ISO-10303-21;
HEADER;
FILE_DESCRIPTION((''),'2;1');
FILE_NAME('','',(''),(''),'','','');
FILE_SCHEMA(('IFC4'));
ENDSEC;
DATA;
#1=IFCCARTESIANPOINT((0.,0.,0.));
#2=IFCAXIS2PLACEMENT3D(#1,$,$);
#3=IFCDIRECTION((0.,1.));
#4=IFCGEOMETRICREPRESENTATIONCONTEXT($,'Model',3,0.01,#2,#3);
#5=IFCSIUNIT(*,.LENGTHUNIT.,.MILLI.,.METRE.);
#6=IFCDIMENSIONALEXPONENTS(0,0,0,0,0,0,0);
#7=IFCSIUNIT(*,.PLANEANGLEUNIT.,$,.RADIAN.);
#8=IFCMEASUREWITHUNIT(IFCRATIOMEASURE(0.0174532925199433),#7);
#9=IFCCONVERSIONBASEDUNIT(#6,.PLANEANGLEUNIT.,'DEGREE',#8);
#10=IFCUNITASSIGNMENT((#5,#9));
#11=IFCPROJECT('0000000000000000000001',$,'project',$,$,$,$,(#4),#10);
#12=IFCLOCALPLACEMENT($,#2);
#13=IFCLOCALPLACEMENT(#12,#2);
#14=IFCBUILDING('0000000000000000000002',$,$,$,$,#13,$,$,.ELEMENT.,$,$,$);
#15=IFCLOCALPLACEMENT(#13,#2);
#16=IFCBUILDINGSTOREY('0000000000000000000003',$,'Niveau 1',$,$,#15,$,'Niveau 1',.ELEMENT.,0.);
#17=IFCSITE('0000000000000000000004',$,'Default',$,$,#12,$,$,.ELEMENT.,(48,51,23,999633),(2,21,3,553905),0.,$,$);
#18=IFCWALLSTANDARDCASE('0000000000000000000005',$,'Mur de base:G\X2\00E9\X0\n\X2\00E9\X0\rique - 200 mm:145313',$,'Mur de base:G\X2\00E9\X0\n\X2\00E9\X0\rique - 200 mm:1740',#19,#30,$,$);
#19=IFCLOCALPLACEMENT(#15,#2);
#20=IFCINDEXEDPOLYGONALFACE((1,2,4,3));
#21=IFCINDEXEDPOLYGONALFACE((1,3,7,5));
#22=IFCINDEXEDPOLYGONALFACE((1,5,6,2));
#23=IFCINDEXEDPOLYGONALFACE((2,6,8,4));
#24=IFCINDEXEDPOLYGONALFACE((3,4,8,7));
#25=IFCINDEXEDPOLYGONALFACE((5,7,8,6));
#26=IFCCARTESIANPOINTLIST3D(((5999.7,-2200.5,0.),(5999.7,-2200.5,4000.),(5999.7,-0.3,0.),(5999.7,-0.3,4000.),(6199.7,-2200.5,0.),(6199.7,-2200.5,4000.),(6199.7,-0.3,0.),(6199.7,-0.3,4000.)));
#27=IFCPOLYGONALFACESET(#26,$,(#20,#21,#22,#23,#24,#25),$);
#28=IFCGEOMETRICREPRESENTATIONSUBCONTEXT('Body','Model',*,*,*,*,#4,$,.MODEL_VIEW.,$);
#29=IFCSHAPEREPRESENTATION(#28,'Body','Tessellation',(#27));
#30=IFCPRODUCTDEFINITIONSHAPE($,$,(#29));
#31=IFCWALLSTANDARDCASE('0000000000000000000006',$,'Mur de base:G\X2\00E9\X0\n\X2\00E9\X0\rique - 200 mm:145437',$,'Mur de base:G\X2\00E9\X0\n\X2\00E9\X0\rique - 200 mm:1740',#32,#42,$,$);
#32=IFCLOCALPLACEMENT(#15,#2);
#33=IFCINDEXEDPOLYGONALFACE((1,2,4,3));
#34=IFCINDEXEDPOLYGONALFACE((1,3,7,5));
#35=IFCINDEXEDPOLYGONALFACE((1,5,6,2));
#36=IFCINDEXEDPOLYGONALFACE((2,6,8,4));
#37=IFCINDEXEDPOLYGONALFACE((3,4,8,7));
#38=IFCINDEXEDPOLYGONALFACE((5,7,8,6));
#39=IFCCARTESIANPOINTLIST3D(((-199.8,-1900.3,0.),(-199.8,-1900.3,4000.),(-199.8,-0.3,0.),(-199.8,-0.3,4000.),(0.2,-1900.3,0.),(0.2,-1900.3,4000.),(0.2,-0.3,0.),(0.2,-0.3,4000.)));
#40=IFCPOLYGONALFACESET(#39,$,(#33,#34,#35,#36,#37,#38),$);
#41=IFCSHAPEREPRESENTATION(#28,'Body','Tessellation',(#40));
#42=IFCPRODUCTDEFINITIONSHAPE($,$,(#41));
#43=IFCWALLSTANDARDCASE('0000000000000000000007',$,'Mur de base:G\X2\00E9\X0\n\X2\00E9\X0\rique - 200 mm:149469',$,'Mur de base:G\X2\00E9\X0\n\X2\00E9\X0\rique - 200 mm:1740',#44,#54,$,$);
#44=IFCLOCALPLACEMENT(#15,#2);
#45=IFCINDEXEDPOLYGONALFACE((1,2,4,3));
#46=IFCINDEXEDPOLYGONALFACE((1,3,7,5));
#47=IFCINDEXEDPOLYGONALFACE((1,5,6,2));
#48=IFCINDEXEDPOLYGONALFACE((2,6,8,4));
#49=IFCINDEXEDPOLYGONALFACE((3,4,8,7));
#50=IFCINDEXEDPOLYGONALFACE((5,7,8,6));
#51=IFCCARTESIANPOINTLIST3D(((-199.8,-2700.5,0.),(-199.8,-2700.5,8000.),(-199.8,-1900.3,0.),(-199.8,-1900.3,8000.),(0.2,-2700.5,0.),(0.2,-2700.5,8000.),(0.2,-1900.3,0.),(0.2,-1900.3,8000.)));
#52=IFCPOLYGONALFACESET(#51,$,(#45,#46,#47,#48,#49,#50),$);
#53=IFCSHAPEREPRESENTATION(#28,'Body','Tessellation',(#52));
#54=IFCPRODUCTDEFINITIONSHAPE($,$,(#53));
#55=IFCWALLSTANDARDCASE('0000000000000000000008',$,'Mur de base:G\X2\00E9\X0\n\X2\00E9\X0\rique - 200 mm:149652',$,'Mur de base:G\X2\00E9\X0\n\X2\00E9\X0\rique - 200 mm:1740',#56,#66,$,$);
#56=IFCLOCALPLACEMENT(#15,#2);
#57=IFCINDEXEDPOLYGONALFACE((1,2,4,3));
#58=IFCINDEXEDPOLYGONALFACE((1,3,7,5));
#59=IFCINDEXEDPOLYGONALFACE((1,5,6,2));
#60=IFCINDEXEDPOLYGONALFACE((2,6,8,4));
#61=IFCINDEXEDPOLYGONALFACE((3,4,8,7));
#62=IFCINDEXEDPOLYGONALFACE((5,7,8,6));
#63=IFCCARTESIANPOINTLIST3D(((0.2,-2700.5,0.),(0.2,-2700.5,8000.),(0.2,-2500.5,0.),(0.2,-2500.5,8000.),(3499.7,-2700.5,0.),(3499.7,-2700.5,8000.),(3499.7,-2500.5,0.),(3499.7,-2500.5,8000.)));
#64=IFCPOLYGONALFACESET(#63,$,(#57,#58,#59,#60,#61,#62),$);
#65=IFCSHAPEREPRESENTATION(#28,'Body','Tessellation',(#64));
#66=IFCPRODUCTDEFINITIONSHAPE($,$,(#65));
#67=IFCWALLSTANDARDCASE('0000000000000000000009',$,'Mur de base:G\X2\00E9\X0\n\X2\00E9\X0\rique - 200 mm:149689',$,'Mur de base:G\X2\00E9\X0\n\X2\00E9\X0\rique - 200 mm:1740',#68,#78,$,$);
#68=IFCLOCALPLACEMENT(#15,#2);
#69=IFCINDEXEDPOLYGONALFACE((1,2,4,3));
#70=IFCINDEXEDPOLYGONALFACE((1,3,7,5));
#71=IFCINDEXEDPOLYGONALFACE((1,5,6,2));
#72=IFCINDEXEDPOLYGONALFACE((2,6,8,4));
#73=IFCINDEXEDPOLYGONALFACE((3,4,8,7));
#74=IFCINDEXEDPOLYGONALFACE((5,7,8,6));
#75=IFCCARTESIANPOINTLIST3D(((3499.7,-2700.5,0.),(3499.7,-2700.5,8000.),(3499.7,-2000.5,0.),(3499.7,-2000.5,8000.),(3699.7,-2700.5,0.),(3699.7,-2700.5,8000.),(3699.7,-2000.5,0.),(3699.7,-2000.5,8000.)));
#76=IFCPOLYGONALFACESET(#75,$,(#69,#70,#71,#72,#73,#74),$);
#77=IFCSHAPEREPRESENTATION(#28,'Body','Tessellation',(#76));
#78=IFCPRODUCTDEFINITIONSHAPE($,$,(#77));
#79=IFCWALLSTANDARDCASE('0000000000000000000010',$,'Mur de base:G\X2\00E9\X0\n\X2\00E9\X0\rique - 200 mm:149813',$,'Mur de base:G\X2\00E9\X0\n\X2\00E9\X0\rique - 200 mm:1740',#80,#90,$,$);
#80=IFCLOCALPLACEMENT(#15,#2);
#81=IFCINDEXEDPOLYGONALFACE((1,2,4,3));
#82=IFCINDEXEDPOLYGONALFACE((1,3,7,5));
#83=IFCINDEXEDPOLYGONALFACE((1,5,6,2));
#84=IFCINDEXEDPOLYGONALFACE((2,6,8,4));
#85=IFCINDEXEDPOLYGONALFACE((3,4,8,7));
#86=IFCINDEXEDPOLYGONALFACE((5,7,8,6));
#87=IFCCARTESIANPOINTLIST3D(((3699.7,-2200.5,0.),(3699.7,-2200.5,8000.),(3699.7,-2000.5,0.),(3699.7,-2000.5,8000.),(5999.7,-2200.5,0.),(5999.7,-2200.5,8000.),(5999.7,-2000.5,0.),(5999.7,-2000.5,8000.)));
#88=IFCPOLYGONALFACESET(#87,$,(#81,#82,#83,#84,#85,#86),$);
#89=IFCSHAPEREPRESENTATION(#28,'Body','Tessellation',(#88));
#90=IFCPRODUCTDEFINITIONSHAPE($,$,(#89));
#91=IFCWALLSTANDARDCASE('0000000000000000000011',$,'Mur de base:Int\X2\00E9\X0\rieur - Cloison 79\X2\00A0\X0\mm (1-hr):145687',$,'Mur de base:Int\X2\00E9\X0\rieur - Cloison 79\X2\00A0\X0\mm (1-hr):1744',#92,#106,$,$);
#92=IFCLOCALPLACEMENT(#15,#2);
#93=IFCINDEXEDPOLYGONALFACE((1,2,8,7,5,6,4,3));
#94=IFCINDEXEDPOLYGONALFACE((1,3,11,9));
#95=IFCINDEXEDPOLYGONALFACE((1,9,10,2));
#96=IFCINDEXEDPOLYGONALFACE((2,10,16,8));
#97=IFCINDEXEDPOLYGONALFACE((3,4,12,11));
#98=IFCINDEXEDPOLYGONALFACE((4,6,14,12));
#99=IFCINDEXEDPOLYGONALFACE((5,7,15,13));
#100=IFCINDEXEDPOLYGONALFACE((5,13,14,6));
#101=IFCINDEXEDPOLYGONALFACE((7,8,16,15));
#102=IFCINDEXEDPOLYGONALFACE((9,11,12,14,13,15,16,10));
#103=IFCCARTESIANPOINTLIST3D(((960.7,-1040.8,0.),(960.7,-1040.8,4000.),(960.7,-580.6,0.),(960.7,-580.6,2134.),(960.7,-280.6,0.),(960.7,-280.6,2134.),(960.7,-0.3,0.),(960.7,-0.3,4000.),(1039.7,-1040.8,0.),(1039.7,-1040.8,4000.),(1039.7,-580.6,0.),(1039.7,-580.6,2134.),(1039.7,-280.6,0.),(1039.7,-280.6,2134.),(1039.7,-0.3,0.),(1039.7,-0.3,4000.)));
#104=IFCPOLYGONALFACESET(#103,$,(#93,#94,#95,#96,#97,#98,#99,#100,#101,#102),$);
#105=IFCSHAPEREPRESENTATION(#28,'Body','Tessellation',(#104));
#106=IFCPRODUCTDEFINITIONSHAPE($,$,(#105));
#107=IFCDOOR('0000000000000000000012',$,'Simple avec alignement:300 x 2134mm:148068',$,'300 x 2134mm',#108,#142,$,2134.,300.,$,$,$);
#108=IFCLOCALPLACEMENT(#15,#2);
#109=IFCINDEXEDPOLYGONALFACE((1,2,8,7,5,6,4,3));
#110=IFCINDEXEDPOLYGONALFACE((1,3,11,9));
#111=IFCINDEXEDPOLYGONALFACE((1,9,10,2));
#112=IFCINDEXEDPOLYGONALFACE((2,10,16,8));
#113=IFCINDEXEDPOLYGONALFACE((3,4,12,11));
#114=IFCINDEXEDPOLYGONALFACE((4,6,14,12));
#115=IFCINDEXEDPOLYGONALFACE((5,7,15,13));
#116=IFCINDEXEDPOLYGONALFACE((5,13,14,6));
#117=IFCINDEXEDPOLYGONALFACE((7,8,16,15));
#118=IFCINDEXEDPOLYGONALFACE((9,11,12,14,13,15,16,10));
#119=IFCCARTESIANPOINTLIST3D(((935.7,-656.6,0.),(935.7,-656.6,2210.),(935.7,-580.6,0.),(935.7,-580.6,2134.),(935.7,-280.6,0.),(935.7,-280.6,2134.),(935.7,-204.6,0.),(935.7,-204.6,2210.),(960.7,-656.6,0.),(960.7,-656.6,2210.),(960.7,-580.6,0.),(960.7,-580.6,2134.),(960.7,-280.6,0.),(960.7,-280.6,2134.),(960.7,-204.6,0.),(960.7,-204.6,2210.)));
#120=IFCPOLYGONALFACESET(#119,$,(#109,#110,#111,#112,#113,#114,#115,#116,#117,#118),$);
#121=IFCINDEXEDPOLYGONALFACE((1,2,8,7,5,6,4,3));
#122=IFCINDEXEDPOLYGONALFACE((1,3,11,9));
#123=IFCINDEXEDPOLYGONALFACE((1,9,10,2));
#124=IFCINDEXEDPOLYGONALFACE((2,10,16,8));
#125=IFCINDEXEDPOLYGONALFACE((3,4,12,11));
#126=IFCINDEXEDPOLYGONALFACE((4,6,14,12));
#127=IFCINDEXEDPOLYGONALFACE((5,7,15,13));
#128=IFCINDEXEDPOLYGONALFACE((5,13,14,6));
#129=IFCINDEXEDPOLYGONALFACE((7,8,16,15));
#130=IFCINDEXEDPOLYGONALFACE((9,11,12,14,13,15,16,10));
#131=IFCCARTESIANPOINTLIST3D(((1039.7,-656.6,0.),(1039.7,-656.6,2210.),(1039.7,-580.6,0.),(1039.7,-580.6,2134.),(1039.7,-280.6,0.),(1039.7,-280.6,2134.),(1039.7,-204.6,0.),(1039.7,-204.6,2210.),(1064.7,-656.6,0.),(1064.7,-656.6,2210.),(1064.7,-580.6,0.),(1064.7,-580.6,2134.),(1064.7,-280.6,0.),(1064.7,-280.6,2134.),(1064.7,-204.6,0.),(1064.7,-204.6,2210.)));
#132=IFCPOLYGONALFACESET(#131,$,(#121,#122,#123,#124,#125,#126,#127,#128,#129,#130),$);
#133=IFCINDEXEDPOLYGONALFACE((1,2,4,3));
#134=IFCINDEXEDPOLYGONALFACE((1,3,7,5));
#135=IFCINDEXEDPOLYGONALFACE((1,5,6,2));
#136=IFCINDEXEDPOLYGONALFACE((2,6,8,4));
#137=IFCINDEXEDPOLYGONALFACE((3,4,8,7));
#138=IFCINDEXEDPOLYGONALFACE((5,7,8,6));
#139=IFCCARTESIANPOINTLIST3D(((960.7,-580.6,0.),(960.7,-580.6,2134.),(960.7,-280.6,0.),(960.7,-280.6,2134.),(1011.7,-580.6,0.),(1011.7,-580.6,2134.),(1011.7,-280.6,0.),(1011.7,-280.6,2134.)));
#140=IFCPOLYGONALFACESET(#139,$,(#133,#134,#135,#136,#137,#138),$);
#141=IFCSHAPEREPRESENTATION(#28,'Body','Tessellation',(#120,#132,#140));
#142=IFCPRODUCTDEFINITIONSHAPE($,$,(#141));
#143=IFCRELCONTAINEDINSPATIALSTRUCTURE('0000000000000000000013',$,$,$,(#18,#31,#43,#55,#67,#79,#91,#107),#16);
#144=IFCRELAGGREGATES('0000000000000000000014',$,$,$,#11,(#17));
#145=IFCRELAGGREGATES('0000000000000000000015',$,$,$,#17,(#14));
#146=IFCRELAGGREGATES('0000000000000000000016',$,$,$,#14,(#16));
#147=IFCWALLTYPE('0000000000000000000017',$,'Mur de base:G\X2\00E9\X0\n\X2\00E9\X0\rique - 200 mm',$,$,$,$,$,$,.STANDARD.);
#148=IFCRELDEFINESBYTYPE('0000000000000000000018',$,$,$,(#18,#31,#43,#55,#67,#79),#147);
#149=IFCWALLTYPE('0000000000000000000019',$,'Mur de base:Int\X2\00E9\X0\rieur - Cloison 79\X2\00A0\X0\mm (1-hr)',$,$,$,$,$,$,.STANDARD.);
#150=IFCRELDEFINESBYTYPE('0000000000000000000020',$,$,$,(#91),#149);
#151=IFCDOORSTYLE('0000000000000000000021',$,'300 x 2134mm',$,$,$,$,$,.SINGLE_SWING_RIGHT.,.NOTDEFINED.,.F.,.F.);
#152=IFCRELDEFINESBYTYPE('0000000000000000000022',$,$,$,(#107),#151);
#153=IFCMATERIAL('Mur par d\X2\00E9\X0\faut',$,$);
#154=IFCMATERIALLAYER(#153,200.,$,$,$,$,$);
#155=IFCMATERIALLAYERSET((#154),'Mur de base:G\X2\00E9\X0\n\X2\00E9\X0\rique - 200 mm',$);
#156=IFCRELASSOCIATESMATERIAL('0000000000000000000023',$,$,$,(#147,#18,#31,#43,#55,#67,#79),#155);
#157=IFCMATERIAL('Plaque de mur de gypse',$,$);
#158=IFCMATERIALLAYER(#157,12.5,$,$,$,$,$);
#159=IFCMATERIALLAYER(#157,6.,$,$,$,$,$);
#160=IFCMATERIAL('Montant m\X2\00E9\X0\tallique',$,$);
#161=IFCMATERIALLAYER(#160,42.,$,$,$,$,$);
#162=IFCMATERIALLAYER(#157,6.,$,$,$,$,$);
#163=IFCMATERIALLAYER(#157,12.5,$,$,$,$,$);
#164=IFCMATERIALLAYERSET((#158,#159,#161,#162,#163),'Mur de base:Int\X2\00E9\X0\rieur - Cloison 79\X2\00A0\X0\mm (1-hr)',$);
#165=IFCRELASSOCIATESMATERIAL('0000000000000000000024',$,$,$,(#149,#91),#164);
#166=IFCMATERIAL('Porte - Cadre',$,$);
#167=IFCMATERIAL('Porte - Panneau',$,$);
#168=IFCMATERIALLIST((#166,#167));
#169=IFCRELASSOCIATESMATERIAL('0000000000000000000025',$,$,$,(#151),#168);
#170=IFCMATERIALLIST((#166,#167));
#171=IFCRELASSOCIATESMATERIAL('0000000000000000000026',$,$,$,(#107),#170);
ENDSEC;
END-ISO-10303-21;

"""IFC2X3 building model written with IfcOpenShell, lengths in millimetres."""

from ifc_helpers import new_model, entity, si_unit, converted_unit, direction, frame, frame_2d, origin, origin_2d_with_axis, place, context, subcontext, project, spatial, polyline, rectangle, outline, extrude, clip, bounded_halfspace, source, transform, mapped, material, material_list, layer, layer_set, layer_usage, type_object, type_shapes, element, fill, save


model = new_model("IFC2X3")

# Units and contexts
model_context = context("Model", 3, precision=0.01, world=origin(), true_north=direction((0.0, 1.0)))
body_context = subcontext(model_context, "Body", "Model", "MODEL_VIEW")
ifc_project = project(units=[si_unit("LENGTHUNIT", "METRE", prefix="MILLI"), converted_unit("PLANEANGLEUNIT", "DEGREE", entity("IfcRatioMeasure", 0.0174532925199433), si_unit("PLANEANGLEUNIT", "RADIAN"), dimensions=[0, 0, 0, 0, 0, 0, 0])], contexts=[model_context])

# Site, building, storey
site_placement = place(None, origin())
site = spatial("IfcSite", under=ifc_project, at=site_placement, Name="Default", CompositionType="ELEMENT", RefLatitude=(48, 51, 23, 999633), RefLongitude=(2, 21, 3, 553905), RefElevation=0.0)
building_placement = place(site_placement, origin())
building = spatial("IfcBuilding", under=site, at=building_placement, CompositionType="ELEMENT")
storey_placement = place(building_placement, origin())
storey = spatial("IfcBuildingStorey", under=building, at=storey_placement, Name="Niveau 1", LongName="Niveau 1", CompositionType="ELEMENT", Elevation=0.0)

# Walls
ifc_material_1 = material(Name="Mur par défaut")
ifc_layer_1 = layer(ifc_material_1, 200.0)
ifc_layer_set_1 = layer_set([ifc_layer_1], Name="Mur de base:Générique - 200 mm")
wall_type_1 = type_object("IfcWallType", Name="Mur de base:Générique - 200 mm", PredefinedType="STANDARD", material=ifc_layer_set_1)
ifc_layer_usage_1 = layer_usage(ifc_layer_set_1, "AXIS2", "NEGATIVE", 100.0)
wall_1_placement = place(storey_placement, frame((6099.7, -0.3, 0.0), z_axis=(0.0, 0.0, 1.0), x_axis=(0.0, -1.0, 0.0)))
element("IfcWallStandardCase", 1, at=wall_1_placement, inside=storey, type_object=wall_type_1, material=ifc_layer_usage_1, Name="Mur de base:Générique - 200 mm:145313", ObjectType="Mur de base:Générique - 200 mm:1740", context=body_context, shape_type="Clipping", body=[
    clip(extrude(rectangle(XDim=2200.1, YDim=200.0, at=frame_2d((1100.1, 0.0), x_axis=(-1.0, 0.0))), origin(), (0.0, 0.0, 1.0), 4000.0), bounded_halfspace(frame((0.0, -100.0, 4000.0), z_axis=(0.0, 0.0, 1.0), x_axis=(0.0, 1.0, 0.0)), False, frame((0.0, -100.0, 4000.0)), polyline([(0.0, 0.0), (960.0, 0.0), (1039.0, 0.0), (2000.0, 0.0), (2000.0, 200.0), (0.0, 200.0), (0.0, 0.0)]))),
])
ifc_layer_usage_2 = layer_usage(ifc_layer_set_1, "AXIS2", "NEGATIVE", 100.0)
wall_2_placement = place(storey_placement, frame((-99.8, -1900.3, 0.0), z_axis=(0.0, 0.0, 1.0), x_axis=(0.0, 1.0, 0.0)))
element("IfcWallStandardCase", 2, at=wall_2_placement, inside=storey, type_object=wall_type_1, material=ifc_layer_usage_2, Name="Mur de base:Générique - 200 mm:145437", ObjectType="Mur de base:Générique - 200 mm:1740", context=body_context, shape_type="Clipping", body=[
    clip(extrude(rectangle(XDim=1900.0, YDim=200.0, at=frame_2d((950.0, 0.0), x_axis=(-1.0, 0.0))), origin(), (0.0, 0.0, 1.0), 4000.0), bounded_halfspace(frame((0.0, -100.0, 4000.0), z_axis=(0.0, 0.0, 1.0), x_axis=(0.0, -1.0, 0.0)), False, frame((0.0, -100.0, 4000.0)), polyline([(0.0, 0.0), (1900.0, 0.0), (1900.0, 200.0), (0.0, 200.0), (0.0, 0.0)]))),
])
ifc_layer_usage_3 = layer_usage(ifc_layer_set_1, "AXIS2", "NEGATIVE", 100.0)
wall_3_placement = place(storey_placement, frame((-99.8, -1900.3, 0.0), z_axis=(0.0, 0.0, 1.0), x_axis=(0.0, -1.0, 0.0)))
element("IfcWallStandardCase", 3, at=wall_3_placement, inside=storey, type_object=wall_type_1, material=ifc_layer_usage_3, Name="Mur de base:Générique - 200 mm:149469", ObjectType="Mur de base:Générique - 200 mm:1740", context=body_context, shape_type="SweptSolid", body=[
    extrude(rectangle(XDim=800.1, YDim=200.0, at=frame_2d((400.1, 0.0), x_axis=(-1.0, 0.0))), origin(), (0.0, 0.0, 1.0), 8000.0),
])
ifc_layer_usage_4 = layer_usage(ifc_layer_set_1, "AXIS2", "NEGATIVE", 100.0)
wall_4_placement = place(storey_placement, frame((0.2, -2600.5, 0.0)))
element("IfcWallStandardCase", 4, at=wall_4_placement, inside=storey, type_object=wall_type_1, material=ifc_layer_usage_4, Name="Mur de base:Générique - 200 mm:149652", ObjectType="Mur de base:Générique - 200 mm:1740", context=body_context, shape_type="SweptSolid", body=[
    extrude(rectangle(XDim=3499.5, YDim=200.0, at=frame_2d((1749.8, 0.0), x_axis=(-1.0, 0.0))), origin(), (0.0, 0.0, 1.0), 8000.0),
])
ifc_layer_usage_5 = layer_usage(ifc_layer_set_1, "AXIS2", "NEGATIVE", 100.0)
wall_5_placement = place(storey_placement, frame((3599.7, -2700.5, 0.0), z_axis=(0.0, 0.0, 1.0), x_axis=(0.0, 1.0, 0.0)))
element("IfcWallStandardCase", 5, at=wall_5_placement, inside=storey, type_object=wall_type_1, material=ifc_layer_usage_5, Name="Mur de base:Générique - 200 mm:149689", ObjectType="Mur de base:Générique - 200 mm:1740", context=body_context, shape_type="SweptSolid", body=[
    extrude(rectangle(XDim=700.0, YDim=200.0, at=frame_2d((350.0, 0.0), x_axis=(-1.0, 0.0))), origin(), (0.0, 0.0, 1.0), 8000.0),
])
ifc_layer_usage_6 = layer_usage(ifc_layer_set_1, "AXIS2", "NEGATIVE", 100.0)
wall_6_placement = place(storey_placement, frame((3699.7, -2100.5, 0.0)))
element("IfcWallStandardCase", 6, at=wall_6_placement, inside=storey, type_object=wall_type_1, material=ifc_layer_usage_6, Name="Mur de base:Générique - 200 mm:149813", ObjectType="Mur de base:Générique - 200 mm:1740", context=body_context, shape_type="SweptSolid", body=[
    extrude(rectangle(XDim=2300.0, YDim=200.0, at=frame_2d((1150.0, 0.0), x_axis=(-1.0, 0.0))), origin(), (0.0, 0.0, 1.0), 8000.0),
])

# Wall, opening, door
ifc_material_2 = material(Name="Plaque de mur de gypse")
ifc_layer_2 = layer(ifc_material_2, 12.5)
ifc_layer_3 = layer(ifc_material_2, 6.0)
ifc_material_3 = material(Name="Montant métallique")
ifc_layer_4 = layer(ifc_material_3, 42.0)
ifc_layer_5 = layer(ifc_material_2, 6.0)
ifc_layer_6 = layer(ifc_material_2, 12.5)
ifc_layer_set_2 = layer_set([ifc_layer_2, ifc_layer_3, ifc_layer_4, ifc_layer_5, ifc_layer_6], Name="Mur de base:Intérieur - Cloison 79 mm (1-hr)")
ifc_layer_usage_7 = layer_usage(ifc_layer_set_2, "AXIS2", "NEGATIVE", 39.5)
wall_type_2 = type_object("IfcWallType", Name="Mur de base:Intérieur - Cloison 79 mm (1-hr)", PredefinedType="STANDARD", material=ifc_layer_set_2)
wall_7_placement = place(storey_placement, frame((1000.2, -0.3, 0.0), z_axis=(0.0, 0.0, 1.0), x_axis=(0.0, -1.0, 0.0)))
wall_7 = element("IfcWallStandardCase", 7, at=wall_7_placement, inside=storey, type_object=wall_type_2, material=ifc_layer_usage_7, Name="Mur de base:Intérieur - Cloison 79 mm (1-hr):145687", ObjectType="Mur de base:Intérieur - Cloison 79 mm (1-hr):1744", context=body_context, shape_type="SweptSolid", body=[
    extrude(rectangle(XDim=1040.5, YDim=79.0, at=frame_2d((520.2, 0.0), x_axis=(-1.0, 0.0))), origin(), (0.0, 0.0, 1.0), 4000.0),
])
opening_1_placement = place(wall_7_placement, frame((580.3, 39.5, 0.0)))
opening_1 = element("IfcOpeningElement", 8, at=opening_1_placement, cuts=wall_7, ObjectType="Opening", context=body_context, shape_type="SweptSolid", body=[
    extrude(rectangle(XDim=300.0, YDim=2134.0, at=frame_2d((1067.0, 150.0), x_axis=(0.0, 1.0))), frame((0.0, 0.0, 0.0), z_axis=(0.0, -1.0, 0.0), x_axis=(0.0, 0.0, 1.0)), (0.0, 0.0, 1.0), 79.0),
])
ifc_material_4 = material(Name="Porte - Cadre")
ifc_material_5 = material(Name="Porte - Panneau")
ifc_material_list_1 = material_list([ifc_material_4, ifc_material_5])
ifc_material_list_2 = material_list([ifc_material_4, ifc_material_5])
door_style_1 = type_object("IfcDoorStyle", Name="300 x 2134mm", ConstructionType="NOTDEFINED", OperationType="SINGLE_SWING_RIGHT", ParameterTakesPrecedence=False, Sizeable=False, material=ifc_material_list_2)
shared_shape_1 = source(origin(), body_context, "Body", "SweptSolid", [
    extrude(outline(polyline([(-226.0, -1124.0), (226.0, -1124.0), (226.0, 1086.0), (150.0, 1086.0), (150.0, -1048.0), (-150.0, -1048.0), (-150.0, 1086.0), (-226.0, 1086.0), (-226.0, -1124.0)])), frame((150.0, 79.0, 1086.0), z_axis=(0.0, 1.0, 0.0), x_axis=(1.0, 0.0, 0.0)), (0.0, 0.0, 1.0), 25.0),
    extrude(outline(polyline([(-1124.0, -226.0), (1086.0, -226.0), (1086.0, -150.0), (-1048.0, -150.0), (-1048.0, 150.0), (1086.0, 150.0), (1086.0, 226.0), (-1124.0, 226.0), (-1124.0, -226.0)])), frame((150.0, -25.0, 1086.0), z_axis=(0.0, 1.0, 0.0), x_axis=(0.0, 0.0, -1.0)), (0.0, 0.0, 1.0), 25.0),
    extrude(rectangle(XDim=51.0, YDim=300.0, at=origin_2d_with_axis()), frame((150.0, 53.5, 0.0), z_axis=(0.0, 0.0, 1.0), x_axis=(0.0, 1.0, 0.0)), (0.0, 0.0, 1.0), 2134.0),
])
type_shapes(door_style_1, [shared_shape_1])
door_1_placement = place(opening_1_placement, frame((0.0, 0.0, 0.0), z_axis=(0.0, 0.0, 1.0), x_axis=(-1.0, 0.0, 0.0)))
door_1 = element("IfcDoor", 9, at=door_1_placement, inside=storey, type_object=door_style_1, material=ifc_material_list_1, Name="Simple avec alignement:300 x 2134mm:148068", ObjectType="300 x 2134mm", OverallHeight=2134.0, OverallWidth=300.0, context=body_context, shape_type="MappedRepresentation", body=[
    mapped(shared_shape_1, transform((0.0, 0.0, 0.0), scale=1.0)),
])
fill(opening_1, door_1)

save(model, "model.ifc")
